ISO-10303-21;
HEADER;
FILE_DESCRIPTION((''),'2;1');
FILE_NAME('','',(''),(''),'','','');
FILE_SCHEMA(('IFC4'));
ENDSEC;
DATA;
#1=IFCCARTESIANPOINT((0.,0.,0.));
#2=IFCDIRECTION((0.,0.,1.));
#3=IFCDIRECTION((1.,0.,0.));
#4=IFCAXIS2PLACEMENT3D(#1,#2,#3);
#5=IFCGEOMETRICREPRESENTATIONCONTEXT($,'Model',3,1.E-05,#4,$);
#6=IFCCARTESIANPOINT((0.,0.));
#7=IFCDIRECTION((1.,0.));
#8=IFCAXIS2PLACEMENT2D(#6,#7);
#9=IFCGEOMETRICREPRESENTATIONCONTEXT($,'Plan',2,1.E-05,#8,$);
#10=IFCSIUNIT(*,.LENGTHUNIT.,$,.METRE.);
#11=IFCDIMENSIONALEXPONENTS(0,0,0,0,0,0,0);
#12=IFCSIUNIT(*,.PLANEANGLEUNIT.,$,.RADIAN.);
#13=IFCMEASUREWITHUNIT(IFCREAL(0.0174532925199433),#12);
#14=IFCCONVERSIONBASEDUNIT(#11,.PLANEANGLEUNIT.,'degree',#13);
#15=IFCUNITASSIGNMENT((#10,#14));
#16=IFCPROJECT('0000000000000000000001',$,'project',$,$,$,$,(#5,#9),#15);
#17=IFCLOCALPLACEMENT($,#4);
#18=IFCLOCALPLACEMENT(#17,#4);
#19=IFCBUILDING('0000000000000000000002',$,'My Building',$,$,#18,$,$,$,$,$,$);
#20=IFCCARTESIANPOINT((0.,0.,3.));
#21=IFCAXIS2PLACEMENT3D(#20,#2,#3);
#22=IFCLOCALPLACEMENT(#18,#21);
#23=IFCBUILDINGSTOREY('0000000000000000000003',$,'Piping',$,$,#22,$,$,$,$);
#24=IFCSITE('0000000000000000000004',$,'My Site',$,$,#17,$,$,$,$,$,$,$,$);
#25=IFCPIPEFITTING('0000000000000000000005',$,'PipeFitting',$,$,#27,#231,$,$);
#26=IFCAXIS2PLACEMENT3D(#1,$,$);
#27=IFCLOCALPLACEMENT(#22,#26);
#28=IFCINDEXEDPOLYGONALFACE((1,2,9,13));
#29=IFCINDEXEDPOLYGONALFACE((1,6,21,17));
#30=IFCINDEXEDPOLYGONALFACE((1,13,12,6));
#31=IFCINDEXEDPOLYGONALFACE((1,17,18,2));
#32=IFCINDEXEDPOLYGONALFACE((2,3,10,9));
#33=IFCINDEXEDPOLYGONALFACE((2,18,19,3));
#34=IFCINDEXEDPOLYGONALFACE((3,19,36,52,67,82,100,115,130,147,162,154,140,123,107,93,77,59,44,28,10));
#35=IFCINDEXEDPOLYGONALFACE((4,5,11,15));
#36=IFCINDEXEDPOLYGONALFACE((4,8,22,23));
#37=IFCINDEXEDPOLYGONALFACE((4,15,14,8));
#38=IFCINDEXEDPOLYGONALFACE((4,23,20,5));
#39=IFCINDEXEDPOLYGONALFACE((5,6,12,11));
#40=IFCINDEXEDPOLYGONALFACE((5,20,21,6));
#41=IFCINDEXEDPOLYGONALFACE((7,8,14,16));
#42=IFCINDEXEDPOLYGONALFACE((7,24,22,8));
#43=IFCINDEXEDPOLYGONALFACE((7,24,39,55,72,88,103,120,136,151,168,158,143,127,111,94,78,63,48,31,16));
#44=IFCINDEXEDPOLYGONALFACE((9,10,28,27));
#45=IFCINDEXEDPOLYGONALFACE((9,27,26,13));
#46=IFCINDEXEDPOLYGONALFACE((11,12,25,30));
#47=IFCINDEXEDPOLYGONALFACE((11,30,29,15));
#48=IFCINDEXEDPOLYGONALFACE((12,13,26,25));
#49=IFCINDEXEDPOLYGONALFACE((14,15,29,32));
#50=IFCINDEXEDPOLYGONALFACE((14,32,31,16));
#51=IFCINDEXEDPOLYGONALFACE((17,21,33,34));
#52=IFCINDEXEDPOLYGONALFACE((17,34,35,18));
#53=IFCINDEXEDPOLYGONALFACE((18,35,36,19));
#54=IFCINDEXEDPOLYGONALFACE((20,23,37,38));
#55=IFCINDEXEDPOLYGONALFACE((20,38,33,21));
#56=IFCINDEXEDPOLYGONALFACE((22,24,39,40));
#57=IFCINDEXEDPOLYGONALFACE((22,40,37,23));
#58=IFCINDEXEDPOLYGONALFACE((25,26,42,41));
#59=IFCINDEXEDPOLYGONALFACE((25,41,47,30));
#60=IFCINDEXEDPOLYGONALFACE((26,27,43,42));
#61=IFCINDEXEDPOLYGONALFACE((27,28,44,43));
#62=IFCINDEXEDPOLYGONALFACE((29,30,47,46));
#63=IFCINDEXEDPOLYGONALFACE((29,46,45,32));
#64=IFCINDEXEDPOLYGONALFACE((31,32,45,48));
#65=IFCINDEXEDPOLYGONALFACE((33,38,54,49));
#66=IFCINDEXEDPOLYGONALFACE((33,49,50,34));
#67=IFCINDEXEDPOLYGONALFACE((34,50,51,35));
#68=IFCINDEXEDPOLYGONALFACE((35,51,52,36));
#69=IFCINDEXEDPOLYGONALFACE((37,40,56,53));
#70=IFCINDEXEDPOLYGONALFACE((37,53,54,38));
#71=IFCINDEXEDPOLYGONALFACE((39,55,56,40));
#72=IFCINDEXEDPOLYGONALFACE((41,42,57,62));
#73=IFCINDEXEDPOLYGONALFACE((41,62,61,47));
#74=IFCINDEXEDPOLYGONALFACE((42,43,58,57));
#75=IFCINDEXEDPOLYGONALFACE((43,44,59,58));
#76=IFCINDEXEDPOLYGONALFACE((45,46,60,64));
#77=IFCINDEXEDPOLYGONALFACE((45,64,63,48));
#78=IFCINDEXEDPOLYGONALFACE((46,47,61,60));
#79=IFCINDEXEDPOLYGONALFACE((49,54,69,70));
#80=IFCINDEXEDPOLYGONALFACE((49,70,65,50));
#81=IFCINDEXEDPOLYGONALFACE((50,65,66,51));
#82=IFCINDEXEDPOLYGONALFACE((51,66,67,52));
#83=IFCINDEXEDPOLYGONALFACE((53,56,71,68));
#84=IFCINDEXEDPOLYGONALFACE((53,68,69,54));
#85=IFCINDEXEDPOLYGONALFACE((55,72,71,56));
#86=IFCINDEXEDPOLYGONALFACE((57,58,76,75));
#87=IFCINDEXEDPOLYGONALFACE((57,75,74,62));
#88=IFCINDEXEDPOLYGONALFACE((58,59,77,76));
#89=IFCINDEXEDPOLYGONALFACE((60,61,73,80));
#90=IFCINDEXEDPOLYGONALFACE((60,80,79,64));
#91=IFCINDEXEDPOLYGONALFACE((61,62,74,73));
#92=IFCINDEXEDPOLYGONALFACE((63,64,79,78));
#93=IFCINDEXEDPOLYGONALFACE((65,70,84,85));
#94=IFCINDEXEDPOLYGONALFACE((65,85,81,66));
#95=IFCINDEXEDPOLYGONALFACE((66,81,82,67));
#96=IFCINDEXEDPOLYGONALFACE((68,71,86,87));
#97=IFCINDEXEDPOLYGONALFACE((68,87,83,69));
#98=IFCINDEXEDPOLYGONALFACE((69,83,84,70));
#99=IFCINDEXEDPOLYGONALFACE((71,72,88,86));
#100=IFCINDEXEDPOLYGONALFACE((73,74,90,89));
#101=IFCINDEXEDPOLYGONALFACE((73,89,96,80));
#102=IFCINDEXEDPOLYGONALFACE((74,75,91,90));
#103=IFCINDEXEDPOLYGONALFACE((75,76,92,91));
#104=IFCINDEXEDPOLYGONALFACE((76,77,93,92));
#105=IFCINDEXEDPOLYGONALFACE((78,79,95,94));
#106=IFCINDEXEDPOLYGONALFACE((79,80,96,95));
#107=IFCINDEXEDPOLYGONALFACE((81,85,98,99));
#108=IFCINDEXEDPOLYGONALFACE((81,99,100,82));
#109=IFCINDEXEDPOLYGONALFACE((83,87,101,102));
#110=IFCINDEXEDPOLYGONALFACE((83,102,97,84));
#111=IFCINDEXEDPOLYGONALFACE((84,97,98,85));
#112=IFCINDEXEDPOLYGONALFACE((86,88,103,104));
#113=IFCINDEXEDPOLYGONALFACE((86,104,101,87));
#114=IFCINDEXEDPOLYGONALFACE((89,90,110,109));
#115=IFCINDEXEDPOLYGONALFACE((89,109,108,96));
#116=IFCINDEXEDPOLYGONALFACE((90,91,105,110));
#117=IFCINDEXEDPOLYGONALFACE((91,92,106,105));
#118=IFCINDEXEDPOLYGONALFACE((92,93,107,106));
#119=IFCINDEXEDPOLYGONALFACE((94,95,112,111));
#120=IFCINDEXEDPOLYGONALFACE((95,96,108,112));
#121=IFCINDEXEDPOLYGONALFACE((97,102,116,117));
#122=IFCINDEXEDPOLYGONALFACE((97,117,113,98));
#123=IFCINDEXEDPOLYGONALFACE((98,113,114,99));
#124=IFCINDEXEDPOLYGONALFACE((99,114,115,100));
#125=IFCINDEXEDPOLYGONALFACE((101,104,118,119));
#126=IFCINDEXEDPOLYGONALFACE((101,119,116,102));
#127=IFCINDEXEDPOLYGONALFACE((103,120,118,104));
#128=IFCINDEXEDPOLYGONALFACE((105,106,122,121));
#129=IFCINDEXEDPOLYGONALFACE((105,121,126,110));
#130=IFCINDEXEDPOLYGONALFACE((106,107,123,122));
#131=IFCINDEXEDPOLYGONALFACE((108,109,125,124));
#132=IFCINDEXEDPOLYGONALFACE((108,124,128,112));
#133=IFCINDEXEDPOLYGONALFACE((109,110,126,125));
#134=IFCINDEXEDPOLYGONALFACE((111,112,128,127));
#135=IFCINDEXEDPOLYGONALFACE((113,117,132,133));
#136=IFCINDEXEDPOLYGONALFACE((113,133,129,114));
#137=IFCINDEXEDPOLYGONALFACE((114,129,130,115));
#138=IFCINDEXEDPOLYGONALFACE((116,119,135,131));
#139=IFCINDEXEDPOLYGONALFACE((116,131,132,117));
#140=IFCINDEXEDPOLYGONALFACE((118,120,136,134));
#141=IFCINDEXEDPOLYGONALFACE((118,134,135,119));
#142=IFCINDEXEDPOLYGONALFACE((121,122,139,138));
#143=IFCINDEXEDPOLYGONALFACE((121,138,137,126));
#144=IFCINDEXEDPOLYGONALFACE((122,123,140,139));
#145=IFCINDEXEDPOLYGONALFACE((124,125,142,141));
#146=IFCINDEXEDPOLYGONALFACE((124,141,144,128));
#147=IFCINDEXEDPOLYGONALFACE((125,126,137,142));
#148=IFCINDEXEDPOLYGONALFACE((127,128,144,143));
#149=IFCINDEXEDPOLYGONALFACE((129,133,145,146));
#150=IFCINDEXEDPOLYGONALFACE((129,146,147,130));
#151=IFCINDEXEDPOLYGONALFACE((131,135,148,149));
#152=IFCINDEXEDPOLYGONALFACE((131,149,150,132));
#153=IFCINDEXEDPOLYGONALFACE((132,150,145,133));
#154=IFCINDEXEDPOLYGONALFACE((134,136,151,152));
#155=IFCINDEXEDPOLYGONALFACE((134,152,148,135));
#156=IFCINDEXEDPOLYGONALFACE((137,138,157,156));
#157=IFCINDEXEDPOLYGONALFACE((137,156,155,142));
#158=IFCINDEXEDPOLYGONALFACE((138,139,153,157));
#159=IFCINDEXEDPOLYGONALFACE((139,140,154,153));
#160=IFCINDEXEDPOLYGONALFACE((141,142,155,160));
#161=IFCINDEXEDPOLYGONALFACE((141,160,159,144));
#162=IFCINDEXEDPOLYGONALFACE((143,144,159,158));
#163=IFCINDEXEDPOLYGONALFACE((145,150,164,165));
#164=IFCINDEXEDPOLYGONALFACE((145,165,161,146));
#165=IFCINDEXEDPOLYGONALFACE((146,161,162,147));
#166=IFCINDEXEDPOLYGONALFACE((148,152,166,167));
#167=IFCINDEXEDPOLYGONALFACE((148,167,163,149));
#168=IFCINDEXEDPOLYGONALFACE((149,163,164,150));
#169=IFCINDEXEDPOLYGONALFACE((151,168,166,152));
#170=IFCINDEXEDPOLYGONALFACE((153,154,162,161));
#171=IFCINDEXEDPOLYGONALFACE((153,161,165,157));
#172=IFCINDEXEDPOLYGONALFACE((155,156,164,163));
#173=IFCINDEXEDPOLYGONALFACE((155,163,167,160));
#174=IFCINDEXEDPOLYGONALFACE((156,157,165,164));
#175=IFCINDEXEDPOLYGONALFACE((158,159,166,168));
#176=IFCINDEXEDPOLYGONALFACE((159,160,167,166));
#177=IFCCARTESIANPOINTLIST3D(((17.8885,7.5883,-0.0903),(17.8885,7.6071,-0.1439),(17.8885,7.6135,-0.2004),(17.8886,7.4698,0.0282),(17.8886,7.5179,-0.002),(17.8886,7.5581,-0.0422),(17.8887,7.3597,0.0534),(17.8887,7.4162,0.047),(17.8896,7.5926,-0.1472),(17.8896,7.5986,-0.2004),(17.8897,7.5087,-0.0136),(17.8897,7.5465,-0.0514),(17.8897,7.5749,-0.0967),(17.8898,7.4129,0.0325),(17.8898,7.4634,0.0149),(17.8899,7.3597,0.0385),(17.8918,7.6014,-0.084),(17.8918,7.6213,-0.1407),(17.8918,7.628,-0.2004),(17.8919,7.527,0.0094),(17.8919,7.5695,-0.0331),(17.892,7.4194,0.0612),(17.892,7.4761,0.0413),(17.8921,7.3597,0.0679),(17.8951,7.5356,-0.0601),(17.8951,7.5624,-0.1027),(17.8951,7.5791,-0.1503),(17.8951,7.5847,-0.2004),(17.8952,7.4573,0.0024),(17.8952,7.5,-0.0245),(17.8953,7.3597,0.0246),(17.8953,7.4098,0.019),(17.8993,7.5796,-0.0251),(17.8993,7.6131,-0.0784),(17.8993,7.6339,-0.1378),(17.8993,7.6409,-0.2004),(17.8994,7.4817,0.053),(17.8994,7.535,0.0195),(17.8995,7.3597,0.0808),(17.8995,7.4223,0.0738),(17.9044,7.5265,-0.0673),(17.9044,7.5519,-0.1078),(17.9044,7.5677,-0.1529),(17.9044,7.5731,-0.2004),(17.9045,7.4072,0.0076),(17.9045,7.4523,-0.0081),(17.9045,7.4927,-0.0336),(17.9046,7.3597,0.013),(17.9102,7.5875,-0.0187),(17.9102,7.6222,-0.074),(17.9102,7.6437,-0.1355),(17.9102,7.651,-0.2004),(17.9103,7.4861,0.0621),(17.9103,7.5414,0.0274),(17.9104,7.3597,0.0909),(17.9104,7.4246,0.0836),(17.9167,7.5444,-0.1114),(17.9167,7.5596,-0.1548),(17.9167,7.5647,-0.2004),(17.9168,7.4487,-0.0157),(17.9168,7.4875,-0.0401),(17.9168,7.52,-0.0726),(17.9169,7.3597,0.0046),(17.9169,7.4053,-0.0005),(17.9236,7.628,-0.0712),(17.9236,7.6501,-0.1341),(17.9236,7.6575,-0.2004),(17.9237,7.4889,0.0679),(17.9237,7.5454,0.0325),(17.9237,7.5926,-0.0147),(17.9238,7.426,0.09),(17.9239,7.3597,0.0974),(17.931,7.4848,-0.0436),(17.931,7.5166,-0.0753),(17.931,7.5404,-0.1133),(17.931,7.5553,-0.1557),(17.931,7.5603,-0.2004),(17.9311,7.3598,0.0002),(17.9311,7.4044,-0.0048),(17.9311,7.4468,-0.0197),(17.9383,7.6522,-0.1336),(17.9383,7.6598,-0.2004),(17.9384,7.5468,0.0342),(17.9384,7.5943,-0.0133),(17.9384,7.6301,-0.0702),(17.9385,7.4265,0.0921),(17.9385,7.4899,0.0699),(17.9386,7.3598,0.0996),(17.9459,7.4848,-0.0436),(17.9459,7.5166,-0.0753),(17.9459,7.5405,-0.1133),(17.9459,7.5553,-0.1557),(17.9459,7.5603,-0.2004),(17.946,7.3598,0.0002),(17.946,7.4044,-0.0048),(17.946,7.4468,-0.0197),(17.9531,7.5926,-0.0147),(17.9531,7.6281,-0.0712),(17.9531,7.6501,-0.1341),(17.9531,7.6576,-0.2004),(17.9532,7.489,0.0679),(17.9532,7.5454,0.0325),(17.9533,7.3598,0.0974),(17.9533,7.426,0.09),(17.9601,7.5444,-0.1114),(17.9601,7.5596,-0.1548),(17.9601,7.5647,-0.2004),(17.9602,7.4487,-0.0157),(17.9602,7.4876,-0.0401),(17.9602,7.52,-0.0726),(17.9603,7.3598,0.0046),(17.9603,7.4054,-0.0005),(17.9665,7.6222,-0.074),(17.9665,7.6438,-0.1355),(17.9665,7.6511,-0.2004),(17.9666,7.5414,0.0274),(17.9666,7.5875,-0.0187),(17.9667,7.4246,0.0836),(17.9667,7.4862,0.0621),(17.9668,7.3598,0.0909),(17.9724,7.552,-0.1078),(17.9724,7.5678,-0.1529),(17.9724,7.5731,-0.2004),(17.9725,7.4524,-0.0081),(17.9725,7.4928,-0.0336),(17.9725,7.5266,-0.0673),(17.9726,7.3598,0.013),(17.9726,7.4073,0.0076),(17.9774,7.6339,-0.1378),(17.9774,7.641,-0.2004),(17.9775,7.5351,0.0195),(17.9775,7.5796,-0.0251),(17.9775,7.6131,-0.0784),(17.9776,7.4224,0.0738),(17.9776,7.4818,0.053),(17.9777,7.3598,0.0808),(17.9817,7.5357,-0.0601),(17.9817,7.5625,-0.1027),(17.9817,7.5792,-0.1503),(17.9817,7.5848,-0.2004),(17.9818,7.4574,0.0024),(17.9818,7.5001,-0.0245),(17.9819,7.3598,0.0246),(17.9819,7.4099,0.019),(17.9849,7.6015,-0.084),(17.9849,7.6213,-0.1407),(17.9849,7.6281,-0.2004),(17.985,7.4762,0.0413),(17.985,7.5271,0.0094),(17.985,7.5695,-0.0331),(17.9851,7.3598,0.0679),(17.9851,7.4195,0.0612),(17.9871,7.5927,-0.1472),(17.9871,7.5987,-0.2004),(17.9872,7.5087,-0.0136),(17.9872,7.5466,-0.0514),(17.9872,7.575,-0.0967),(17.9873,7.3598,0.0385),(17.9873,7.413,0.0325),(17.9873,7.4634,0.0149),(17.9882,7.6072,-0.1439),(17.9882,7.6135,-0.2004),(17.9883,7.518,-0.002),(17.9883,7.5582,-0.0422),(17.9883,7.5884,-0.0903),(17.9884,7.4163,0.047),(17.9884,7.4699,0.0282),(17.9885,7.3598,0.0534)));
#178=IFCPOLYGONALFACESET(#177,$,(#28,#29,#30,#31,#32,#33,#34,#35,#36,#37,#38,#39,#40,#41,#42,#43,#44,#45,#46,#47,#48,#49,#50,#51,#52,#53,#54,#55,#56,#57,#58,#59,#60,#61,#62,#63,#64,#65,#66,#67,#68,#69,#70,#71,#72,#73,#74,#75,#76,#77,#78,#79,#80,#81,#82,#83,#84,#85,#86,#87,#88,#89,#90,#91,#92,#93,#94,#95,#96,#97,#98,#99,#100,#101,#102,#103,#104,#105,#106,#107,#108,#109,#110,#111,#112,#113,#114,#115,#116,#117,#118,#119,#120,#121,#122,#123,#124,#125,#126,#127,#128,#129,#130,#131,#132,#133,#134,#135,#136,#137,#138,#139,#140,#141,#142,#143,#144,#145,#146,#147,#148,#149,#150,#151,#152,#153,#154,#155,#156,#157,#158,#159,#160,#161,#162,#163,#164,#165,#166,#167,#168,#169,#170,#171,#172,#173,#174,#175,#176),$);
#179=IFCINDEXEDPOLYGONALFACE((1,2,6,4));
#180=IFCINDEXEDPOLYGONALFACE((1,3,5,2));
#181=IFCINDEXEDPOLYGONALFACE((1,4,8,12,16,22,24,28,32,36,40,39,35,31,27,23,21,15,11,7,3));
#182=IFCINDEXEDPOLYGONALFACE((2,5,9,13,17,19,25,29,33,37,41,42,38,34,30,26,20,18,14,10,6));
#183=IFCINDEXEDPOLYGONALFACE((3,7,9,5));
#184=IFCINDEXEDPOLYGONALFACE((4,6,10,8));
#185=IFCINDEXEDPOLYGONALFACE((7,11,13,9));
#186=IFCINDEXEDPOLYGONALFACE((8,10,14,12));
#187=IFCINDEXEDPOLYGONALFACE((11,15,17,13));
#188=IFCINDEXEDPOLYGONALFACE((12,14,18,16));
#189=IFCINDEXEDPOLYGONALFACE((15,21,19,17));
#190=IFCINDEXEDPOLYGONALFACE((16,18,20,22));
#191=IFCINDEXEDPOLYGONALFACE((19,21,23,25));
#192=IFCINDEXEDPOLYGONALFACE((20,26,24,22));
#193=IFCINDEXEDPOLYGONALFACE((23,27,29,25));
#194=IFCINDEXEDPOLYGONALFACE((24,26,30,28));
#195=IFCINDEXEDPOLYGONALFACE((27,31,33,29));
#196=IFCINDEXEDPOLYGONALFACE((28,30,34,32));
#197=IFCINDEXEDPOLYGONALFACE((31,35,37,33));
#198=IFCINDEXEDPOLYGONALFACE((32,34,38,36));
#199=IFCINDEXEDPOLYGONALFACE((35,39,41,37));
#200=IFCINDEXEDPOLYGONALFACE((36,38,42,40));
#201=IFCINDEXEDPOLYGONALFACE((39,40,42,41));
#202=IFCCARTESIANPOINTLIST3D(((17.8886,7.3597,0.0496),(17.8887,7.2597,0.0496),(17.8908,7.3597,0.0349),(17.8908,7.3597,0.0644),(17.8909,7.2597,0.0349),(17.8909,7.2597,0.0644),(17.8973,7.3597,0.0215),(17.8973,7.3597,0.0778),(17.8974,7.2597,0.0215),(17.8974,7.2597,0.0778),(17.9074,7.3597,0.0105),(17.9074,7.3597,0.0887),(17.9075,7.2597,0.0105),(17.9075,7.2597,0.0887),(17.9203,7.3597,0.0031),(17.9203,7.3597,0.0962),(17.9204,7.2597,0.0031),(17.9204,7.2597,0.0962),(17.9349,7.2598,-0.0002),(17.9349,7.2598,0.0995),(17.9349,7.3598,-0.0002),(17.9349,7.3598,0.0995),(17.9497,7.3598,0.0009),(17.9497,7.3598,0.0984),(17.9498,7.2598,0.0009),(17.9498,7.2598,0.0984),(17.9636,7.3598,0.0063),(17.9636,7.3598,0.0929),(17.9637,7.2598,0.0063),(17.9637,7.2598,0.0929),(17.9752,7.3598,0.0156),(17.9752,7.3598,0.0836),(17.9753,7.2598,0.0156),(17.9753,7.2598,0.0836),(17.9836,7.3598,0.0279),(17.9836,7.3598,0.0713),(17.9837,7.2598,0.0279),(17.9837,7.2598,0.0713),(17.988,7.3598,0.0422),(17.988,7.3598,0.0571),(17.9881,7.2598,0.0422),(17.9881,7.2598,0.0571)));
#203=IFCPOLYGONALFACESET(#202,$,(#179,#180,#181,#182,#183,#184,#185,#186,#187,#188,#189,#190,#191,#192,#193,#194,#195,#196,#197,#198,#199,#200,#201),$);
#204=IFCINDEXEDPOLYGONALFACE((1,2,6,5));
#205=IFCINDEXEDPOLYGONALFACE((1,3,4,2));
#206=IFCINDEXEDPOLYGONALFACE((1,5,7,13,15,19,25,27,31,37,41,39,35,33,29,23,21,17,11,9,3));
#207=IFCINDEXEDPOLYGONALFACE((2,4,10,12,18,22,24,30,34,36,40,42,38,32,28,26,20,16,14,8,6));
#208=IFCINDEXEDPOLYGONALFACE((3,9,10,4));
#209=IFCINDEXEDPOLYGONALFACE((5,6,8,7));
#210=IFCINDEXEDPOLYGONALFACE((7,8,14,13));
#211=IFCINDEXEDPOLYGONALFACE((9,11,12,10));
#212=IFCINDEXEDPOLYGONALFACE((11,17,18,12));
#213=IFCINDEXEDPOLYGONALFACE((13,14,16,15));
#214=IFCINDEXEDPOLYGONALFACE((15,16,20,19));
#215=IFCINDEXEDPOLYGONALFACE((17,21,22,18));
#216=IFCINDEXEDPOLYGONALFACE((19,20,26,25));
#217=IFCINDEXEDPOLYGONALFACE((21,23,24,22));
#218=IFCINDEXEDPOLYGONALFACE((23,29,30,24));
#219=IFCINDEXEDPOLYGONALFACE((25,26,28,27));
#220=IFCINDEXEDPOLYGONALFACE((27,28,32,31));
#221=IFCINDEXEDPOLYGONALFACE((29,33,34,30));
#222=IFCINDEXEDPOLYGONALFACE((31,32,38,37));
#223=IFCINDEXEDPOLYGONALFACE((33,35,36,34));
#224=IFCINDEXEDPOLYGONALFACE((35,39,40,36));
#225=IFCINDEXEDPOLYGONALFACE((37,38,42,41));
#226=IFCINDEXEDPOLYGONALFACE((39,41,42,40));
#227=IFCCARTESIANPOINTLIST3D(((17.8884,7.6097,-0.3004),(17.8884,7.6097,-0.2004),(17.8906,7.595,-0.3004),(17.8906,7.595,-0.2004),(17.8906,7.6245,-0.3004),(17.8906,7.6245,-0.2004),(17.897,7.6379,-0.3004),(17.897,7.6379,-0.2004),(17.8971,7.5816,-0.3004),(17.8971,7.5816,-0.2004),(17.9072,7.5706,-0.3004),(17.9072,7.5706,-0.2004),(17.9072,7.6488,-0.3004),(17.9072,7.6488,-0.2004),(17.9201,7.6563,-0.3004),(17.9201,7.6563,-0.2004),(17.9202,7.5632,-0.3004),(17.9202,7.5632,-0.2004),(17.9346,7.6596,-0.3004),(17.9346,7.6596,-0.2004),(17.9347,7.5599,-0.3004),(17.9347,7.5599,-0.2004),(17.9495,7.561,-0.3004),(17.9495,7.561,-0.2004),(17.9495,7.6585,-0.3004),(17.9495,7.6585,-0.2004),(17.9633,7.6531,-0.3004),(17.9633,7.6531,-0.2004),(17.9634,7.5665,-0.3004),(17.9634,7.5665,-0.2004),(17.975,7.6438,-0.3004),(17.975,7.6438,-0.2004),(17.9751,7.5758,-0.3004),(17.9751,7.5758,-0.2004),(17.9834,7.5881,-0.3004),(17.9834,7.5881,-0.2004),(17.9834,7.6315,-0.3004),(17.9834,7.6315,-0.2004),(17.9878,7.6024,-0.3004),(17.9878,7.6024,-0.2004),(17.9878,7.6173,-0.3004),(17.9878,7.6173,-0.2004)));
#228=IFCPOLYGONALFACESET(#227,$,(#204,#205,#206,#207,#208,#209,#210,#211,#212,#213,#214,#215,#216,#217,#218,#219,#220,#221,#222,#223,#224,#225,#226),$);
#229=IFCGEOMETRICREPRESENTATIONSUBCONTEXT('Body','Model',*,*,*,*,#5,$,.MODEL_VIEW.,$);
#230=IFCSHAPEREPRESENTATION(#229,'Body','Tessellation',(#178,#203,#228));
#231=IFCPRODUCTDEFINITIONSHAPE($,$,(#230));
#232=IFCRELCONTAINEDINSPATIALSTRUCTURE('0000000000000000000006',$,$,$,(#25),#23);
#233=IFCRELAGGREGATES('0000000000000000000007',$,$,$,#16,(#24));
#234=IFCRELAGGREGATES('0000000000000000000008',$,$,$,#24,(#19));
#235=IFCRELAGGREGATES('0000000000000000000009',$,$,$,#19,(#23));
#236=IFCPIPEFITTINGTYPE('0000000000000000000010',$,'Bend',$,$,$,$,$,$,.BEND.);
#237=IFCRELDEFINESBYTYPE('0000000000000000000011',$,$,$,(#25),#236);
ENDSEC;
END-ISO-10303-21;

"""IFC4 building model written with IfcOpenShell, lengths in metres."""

from ifc_helpers import new_model, entity, si_unit, converted_unit, frame, origin_with_axes, origin_2d_with_axis, place, context, subcontext, project, spatial, circle, extrude, source, transform, mapped, type_object, type_shapes, element, save


model = new_model("IFC4")

# Units and contexts
model_context = context("Model", 3, precision=1e-05, world=origin_with_axes())
plan_context = context("Plan", 2, precision=1e-05, world=origin_2d_with_axis())
body_context = subcontext(model_context, "Body", "Model", "MODEL_VIEW")
ifc_project = project(units=[si_unit("LENGTHUNIT", "METRE"), converted_unit("PLANEANGLEUNIT", "degree", entity("IfcReal", 0.0174532925199433), si_unit("PLANEANGLEUNIT", "RADIAN"), dimensions=[0, 0, 0, 0, 0, 0, 0])], contexts=[model_context, plan_context])

# Site, building, storey
site_placement = place(None, origin_with_axes())
site = spatial("IfcSite", under=ifc_project, at=site_placement, Name="My Site")
building_placement = place(site_placement, origin_with_axes())
building = spatial("IfcBuilding", under=site, at=building_placement, Name="My Building")
storey_placement = place(building_placement, frame((0.0, 0.0, 3.0), z_axis=(0.0, 0.0, 1.0), x_axis=(1.0, 0.0, 0.0)))
storey = spatial("IfcBuildingStorey", under=building, at=storey_placement, Name="Piping")

# Pipe fitting
pipe_fitting_type_1 = type_object("IfcPipeFittingType", Name="Bend", PredefinedType="BEND")
shared_shape = source(origin_with_axes(), body_context, "Body", "SolidModel", [
    entity("IfcSweptDiskSolid", entity("IfcIndexedPolyCurve", entity("IfcCartesianPointList3D", [[0.0, 0.0, 0.1], [0.0, -0.0732, 0.2768], [0.0, -0.25, 0.35]]), [entity("IfcArcIndex", [1, 2, 3])]), 0.05),
    extrude(circle(Radius=0.05), origin_with_axes(), (0.0, 0.0, 1.0), 0.1),
    extrude(circle(Radius=0.05), frame((0.0, -0.25, 0.35), z_axis=(0.0, -1.0, -0.000001), x_axis=(1.0, 0.0, 0.0)), (0.0, 0.0, 1.0), 0.1),
])
type_shapes(pipe_fitting_type_1, [shared_shape])
for number, where, z_axis, x_axis, name in (
    (1, (17.9387, 7.2598, 0.0496), (-0.000872, 1.0, 0.000001), (-1.0, -0.000872, 0.0), "PipeFitting"),
):
    element("IfcPipeFitting", number, at=place(storey_placement, frame(where, z_axis=z_axis, x_axis=x_axis)), inside=storey, type_object=pipe_fitting_type_1, Name=name, context=body_context, shape_type="MappedRepresentation", body=[
        mapped(shared_shape, transform((0.0, 0.0, 0.0), x_axis=(1.0, 0.0, 0.0), y_axis=(0.0, 1.0, 0.0), z_axis=(0.0, 0.0, 1.0), scale=1.0)),
    ])

save(model, "model.ifc")
